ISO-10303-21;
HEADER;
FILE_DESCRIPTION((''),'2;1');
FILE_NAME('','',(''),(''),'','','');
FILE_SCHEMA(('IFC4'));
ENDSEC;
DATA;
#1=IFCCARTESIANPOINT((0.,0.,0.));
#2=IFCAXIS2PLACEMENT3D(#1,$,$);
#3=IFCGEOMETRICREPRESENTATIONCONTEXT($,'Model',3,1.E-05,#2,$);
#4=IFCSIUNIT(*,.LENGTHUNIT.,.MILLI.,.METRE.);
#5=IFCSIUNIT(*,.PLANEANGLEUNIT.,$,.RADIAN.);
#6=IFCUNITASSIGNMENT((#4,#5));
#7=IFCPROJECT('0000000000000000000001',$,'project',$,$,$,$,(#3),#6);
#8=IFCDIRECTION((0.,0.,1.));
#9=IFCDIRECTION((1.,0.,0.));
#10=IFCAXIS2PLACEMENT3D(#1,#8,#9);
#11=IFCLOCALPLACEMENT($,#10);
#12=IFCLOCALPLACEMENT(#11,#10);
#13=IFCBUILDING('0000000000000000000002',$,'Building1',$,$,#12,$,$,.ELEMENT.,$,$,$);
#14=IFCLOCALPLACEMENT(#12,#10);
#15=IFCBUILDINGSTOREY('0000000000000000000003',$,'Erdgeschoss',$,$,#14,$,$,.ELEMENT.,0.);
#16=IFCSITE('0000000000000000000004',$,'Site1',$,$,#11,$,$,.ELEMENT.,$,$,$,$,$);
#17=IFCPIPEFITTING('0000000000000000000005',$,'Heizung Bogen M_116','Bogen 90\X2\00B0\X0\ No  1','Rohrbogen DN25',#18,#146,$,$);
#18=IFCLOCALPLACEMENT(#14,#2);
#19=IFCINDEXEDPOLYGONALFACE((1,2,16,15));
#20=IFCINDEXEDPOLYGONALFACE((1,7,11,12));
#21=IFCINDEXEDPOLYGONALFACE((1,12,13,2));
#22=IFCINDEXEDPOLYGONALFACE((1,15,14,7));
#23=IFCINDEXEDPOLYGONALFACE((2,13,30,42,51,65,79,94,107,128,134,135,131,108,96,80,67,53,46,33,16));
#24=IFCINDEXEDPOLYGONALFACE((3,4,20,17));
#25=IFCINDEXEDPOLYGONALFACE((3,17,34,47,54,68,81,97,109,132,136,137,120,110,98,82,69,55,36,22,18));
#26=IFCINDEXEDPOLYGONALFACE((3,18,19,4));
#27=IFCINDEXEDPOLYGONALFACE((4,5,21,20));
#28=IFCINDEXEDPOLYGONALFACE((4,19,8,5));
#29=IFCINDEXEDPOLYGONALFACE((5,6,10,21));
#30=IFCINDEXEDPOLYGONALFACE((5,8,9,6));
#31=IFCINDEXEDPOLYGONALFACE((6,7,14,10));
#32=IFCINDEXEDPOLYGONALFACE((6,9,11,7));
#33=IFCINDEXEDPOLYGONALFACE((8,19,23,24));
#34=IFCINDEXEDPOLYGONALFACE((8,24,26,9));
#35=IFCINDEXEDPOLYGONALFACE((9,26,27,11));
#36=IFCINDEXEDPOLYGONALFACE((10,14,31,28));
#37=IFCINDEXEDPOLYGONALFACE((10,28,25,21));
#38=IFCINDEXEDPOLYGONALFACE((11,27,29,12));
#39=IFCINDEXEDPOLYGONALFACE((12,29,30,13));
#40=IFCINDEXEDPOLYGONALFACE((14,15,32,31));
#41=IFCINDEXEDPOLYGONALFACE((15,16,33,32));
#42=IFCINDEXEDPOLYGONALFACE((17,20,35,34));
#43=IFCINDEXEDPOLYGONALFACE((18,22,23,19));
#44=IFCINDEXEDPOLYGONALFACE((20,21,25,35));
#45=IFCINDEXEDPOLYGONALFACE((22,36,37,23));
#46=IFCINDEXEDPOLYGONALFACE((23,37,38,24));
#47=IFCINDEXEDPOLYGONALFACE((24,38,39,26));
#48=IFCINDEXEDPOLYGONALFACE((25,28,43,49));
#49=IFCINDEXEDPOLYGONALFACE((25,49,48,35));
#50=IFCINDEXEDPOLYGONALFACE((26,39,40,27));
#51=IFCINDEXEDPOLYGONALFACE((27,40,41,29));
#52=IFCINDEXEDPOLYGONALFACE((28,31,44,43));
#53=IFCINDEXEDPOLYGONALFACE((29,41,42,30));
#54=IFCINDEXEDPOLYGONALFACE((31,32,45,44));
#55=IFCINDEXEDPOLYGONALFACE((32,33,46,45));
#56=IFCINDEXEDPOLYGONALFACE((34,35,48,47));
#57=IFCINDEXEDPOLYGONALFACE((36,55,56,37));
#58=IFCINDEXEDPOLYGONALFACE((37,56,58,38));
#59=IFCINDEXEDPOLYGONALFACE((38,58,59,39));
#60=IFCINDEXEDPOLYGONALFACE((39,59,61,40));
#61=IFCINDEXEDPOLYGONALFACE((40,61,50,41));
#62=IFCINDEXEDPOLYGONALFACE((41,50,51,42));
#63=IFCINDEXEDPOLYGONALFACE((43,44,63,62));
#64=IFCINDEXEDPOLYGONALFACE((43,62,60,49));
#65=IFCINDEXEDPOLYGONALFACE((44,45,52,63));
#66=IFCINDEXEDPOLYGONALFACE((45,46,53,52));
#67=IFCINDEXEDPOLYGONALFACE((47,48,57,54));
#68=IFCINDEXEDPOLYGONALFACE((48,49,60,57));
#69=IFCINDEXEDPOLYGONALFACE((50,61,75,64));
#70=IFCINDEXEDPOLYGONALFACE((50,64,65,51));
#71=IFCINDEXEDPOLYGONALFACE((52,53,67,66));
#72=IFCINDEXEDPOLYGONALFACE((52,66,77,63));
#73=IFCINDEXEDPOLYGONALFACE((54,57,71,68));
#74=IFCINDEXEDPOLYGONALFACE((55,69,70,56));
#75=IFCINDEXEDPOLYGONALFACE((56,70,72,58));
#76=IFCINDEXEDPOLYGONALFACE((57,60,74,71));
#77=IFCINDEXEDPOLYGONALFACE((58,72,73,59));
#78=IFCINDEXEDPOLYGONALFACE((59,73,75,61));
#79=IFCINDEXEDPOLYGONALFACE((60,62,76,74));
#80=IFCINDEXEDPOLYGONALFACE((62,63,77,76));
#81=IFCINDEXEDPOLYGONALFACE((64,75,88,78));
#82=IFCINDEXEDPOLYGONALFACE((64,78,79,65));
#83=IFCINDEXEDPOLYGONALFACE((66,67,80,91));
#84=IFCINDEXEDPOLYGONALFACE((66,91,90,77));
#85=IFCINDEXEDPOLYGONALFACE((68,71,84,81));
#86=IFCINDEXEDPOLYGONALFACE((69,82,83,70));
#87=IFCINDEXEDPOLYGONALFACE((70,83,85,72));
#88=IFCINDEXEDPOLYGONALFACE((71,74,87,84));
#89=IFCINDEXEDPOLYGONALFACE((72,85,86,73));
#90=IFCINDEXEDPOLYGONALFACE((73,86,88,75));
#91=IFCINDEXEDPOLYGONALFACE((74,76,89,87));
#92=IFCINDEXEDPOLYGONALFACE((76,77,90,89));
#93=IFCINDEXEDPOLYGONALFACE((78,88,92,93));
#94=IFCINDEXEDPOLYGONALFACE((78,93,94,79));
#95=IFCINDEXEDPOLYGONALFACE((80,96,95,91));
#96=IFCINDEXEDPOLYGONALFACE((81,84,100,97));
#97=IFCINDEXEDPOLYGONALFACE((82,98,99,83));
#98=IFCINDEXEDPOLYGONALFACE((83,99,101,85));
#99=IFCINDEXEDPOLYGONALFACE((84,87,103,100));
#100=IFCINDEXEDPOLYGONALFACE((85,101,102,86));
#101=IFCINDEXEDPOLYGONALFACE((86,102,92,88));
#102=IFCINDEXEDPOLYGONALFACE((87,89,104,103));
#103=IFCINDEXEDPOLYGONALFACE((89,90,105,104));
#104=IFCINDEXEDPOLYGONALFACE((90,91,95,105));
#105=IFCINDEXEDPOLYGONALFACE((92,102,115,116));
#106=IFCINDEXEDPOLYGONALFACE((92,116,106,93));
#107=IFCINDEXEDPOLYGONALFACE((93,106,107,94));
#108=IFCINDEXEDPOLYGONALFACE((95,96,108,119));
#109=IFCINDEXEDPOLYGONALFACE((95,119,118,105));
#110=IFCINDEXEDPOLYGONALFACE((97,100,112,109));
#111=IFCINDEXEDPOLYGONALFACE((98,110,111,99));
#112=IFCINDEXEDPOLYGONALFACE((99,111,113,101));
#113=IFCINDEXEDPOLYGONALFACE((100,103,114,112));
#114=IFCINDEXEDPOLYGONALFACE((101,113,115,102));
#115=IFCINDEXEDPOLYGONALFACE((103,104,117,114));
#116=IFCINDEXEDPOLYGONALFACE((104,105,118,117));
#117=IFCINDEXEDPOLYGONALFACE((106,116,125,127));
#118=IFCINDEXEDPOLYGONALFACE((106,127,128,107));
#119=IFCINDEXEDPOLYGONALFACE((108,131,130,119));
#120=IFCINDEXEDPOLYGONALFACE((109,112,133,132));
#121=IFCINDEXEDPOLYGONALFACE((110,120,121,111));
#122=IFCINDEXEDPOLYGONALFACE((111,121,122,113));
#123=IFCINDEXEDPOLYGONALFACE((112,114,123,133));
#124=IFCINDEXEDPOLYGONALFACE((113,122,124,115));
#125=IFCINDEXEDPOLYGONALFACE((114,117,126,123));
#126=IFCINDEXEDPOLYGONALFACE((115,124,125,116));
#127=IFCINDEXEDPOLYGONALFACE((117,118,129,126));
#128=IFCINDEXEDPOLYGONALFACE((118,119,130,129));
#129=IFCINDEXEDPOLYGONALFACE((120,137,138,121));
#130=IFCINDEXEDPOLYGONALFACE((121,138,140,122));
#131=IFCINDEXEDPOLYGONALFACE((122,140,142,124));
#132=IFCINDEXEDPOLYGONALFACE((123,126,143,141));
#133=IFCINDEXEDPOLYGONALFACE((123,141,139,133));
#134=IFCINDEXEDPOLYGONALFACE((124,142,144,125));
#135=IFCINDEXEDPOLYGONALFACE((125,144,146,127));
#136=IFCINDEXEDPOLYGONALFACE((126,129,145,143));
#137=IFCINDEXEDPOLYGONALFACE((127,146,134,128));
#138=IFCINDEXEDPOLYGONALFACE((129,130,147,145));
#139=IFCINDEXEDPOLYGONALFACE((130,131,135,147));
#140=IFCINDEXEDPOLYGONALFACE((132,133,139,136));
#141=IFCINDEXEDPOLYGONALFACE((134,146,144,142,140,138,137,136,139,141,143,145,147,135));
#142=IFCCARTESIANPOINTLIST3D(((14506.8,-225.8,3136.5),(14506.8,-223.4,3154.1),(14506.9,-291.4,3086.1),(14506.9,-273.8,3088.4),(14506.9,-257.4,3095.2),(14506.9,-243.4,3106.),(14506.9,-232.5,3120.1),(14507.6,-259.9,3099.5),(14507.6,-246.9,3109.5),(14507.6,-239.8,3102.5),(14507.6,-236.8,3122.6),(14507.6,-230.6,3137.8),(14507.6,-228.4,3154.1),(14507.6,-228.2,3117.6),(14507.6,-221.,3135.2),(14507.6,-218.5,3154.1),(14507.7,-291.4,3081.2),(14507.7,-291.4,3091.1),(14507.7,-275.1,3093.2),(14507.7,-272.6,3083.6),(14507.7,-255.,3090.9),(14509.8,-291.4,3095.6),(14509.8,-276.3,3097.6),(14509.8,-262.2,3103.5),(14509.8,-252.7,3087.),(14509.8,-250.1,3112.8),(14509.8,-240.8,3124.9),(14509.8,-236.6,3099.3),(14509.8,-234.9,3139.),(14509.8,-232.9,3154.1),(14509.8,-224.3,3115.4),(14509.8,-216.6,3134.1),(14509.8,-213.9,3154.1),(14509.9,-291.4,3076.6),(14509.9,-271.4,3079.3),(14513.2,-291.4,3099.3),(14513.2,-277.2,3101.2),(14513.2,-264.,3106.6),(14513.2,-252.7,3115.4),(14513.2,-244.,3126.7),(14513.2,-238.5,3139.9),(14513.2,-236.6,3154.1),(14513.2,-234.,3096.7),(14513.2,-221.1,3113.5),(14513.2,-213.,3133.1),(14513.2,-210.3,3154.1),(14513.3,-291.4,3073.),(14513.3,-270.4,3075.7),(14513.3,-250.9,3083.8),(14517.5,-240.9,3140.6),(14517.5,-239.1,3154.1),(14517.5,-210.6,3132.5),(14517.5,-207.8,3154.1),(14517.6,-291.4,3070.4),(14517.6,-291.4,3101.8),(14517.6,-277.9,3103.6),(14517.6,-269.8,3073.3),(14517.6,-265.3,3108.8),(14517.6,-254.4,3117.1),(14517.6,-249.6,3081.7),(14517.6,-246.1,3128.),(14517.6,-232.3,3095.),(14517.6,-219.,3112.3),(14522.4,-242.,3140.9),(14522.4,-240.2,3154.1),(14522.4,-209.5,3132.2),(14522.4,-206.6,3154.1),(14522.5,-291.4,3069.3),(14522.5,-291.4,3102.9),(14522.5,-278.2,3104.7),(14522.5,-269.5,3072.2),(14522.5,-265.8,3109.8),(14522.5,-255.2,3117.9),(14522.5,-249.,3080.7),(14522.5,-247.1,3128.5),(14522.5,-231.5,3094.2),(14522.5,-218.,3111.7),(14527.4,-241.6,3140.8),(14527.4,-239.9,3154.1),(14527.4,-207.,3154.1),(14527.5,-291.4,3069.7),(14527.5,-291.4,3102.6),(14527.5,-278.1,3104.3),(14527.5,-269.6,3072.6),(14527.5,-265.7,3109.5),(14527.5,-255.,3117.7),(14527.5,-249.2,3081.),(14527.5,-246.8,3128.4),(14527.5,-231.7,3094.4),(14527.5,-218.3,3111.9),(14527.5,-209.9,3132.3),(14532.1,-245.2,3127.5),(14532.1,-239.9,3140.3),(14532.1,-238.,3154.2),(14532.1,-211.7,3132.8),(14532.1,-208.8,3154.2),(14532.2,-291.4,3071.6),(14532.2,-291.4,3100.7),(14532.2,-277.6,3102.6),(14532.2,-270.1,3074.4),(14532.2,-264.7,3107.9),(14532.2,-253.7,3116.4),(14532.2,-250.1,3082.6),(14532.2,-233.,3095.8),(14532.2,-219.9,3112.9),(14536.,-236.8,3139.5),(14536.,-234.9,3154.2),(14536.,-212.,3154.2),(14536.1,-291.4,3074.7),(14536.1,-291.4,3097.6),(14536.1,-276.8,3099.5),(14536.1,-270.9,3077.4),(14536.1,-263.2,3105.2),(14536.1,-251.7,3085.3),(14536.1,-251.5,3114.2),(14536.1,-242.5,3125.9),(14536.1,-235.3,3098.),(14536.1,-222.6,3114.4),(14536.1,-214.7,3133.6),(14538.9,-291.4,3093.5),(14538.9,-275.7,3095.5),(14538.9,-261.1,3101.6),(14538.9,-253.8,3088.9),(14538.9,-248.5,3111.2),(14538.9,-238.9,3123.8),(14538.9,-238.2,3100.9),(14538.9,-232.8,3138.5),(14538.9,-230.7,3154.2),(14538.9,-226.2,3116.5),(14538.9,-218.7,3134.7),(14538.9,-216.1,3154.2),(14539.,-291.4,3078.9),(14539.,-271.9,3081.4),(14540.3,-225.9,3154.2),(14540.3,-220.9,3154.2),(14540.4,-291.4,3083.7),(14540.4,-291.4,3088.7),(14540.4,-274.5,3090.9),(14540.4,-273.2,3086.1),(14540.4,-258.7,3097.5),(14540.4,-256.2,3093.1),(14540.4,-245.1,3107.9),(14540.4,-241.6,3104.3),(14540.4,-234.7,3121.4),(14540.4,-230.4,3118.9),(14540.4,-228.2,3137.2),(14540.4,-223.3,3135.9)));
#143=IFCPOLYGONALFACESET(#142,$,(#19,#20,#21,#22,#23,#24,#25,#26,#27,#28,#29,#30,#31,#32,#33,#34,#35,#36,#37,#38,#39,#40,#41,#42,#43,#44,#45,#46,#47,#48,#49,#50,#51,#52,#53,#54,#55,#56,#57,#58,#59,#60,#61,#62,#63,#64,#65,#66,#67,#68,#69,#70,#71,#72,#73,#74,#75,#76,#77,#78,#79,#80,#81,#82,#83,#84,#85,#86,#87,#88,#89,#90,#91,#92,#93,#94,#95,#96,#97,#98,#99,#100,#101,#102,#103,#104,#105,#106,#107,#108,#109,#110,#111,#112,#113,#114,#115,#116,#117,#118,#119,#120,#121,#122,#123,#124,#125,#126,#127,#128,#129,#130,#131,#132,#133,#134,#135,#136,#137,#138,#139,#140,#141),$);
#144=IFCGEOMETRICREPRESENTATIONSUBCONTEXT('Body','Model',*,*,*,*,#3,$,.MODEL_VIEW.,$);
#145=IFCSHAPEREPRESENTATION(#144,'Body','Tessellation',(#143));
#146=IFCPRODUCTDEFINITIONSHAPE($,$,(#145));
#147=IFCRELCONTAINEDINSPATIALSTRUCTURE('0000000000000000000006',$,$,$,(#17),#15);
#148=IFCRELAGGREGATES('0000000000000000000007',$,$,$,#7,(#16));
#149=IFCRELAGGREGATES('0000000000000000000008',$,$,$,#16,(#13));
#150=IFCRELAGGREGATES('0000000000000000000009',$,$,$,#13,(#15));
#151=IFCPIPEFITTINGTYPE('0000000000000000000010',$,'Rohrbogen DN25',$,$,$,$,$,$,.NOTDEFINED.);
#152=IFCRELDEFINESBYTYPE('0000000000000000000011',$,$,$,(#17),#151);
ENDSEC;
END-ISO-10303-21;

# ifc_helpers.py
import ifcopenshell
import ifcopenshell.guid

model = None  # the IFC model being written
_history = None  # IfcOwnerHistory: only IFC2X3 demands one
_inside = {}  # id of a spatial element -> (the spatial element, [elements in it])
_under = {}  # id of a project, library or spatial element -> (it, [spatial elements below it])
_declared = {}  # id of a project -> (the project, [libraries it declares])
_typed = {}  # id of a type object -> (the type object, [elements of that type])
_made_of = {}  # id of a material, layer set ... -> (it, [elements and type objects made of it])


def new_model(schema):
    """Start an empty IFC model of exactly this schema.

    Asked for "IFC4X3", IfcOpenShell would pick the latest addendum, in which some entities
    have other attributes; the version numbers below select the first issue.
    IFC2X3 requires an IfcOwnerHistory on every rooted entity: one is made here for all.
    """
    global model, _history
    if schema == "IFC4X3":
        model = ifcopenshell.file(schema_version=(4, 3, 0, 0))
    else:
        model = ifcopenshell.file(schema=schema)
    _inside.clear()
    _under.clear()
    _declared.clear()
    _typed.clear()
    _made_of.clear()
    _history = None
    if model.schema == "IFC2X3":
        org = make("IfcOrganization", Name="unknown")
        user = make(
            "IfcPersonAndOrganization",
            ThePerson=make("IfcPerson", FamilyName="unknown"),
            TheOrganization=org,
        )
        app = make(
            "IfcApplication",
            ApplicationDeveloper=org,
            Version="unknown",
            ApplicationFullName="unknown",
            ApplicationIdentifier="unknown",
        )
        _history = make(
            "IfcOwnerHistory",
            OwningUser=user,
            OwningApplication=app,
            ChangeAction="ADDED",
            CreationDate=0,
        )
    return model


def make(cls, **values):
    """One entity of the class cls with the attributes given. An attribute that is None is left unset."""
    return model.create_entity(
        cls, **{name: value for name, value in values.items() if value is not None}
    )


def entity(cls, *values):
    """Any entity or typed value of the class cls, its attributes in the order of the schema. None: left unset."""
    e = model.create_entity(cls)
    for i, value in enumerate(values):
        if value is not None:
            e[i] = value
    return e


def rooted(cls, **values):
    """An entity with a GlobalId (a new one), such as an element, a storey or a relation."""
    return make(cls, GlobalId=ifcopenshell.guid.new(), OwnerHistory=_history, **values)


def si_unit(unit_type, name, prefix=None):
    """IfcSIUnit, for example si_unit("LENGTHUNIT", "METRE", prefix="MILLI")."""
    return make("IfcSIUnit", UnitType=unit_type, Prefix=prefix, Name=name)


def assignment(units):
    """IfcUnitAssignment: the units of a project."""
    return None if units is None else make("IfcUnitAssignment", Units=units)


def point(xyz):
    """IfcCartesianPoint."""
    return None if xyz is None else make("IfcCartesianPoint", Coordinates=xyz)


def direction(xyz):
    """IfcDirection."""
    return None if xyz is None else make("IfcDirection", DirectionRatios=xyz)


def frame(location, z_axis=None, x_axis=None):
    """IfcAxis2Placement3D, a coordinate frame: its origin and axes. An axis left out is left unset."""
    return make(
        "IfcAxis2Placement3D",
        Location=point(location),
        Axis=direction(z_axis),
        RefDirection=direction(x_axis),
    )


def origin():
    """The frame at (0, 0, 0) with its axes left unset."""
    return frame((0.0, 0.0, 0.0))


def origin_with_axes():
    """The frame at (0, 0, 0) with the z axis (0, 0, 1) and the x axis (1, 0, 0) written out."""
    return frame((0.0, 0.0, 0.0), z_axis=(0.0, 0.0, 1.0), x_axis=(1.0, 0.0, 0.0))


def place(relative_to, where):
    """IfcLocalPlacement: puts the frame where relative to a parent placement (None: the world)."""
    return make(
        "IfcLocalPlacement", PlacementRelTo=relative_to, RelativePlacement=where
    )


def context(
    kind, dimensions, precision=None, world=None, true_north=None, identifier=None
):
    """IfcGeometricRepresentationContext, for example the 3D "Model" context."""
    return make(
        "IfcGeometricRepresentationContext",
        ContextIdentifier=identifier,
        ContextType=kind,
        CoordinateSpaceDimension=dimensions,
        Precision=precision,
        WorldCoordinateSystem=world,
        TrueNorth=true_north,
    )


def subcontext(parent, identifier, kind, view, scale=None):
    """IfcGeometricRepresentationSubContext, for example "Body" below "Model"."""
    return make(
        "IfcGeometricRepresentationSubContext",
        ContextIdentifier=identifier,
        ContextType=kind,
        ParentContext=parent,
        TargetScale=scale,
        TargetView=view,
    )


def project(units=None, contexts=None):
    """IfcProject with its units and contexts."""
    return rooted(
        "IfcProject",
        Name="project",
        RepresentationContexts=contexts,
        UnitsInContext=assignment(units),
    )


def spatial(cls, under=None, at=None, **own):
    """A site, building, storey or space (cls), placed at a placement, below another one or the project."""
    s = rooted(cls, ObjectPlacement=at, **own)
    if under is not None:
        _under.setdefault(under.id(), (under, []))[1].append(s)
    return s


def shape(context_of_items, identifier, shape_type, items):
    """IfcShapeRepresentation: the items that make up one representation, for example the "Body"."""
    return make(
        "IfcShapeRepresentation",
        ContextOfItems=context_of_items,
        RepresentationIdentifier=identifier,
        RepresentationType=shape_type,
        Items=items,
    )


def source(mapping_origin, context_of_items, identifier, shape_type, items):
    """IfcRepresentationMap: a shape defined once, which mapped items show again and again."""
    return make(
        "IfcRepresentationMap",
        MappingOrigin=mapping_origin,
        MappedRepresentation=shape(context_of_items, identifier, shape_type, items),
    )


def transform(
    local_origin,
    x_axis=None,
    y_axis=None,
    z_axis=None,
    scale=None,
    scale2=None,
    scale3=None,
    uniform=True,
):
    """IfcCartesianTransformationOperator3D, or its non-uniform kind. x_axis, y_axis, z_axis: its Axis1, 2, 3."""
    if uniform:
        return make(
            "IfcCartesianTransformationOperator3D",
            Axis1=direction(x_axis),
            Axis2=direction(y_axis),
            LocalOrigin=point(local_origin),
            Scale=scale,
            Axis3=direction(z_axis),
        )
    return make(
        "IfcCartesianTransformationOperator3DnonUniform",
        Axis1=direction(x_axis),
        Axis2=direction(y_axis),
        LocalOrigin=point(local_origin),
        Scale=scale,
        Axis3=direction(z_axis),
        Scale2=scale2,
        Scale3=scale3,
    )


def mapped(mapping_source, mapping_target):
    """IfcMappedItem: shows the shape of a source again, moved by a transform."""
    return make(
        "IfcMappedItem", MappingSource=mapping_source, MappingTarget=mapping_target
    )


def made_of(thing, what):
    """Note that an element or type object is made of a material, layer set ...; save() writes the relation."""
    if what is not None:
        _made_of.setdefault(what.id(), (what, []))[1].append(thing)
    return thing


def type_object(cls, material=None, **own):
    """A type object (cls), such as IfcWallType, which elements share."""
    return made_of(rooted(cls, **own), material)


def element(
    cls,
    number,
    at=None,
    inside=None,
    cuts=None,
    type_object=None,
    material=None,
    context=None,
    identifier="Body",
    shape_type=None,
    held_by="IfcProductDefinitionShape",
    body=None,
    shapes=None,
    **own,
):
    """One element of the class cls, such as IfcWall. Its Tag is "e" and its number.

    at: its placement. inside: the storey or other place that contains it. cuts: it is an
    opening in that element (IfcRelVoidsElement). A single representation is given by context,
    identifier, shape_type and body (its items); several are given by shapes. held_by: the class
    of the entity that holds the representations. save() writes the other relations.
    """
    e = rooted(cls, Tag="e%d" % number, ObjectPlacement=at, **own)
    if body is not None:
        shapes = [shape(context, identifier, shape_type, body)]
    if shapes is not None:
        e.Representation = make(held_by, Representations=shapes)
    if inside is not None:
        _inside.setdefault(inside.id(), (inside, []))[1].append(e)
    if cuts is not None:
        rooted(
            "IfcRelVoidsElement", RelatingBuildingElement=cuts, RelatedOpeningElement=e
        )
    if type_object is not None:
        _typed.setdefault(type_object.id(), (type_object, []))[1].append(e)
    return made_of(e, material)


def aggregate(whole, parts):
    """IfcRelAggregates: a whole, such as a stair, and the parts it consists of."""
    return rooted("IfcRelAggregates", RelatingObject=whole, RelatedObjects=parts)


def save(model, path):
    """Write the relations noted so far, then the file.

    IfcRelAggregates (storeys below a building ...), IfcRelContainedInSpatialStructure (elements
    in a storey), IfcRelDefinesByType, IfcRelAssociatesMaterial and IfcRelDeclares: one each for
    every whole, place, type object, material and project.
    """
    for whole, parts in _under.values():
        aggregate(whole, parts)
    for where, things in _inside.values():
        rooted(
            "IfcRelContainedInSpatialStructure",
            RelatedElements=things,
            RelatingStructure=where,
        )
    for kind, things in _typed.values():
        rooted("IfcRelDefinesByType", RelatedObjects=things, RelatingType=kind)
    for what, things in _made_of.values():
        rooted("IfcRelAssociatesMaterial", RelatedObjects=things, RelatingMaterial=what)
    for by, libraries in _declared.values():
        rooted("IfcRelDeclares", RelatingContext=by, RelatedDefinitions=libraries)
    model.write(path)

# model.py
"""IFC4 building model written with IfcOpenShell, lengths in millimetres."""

from ifc_helpers import new_model, entity, si_unit, frame, origin, origin_with_axes, place, context, subcontext, project, spatial, source, transform, mapped, type_object, element, save


model = new_model("IFC4")

# Units and contexts
model_context = context("Model", 3, precision=1e-05, world=origin())
body_context = subcontext(model_context, "Body", "Model", "MODEL_VIEW")
ifc_project = project(units=[si_unit("LENGTHUNIT", "METRE", prefix="MILLI"), si_unit("PLANEANGLEUNIT", "RADIAN")], contexts=[model_context])

# Site, building, storey
site_placement = place(None, origin_with_axes())
site = spatial("IfcSite", under=ifc_project, at=site_placement, Name="Site1", CompositionType="ELEMENT")
building_placement = place(site_placement, origin_with_axes())
building = spatial("IfcBuilding", under=site, at=building_placement, Name="Building1", CompositionType="ELEMENT")
storey_placement = place(building_placement, origin_with_axes())
storey = spatial("IfcBuildingStorey", under=building, at=storey_placement, Name="Erdgeschoss", CompositionType="ELEMENT", Elevation=0.0)

# Pipe fitting
pipe_fitting_type = type_object("IfcPipeFittingType", Name="Rohrbogen DN25", PredefinedType="NOTDEFINED")
shared_shape_1 = source(origin_with_axes(), body_context, "Body", "SolidModel", [
    entity("IfcRevolvedAreaSolid", entity("IfcCircleProfileDef", "AREA", None, entity("IfcAxis2Placement2D", entity("IfcCartesianPoint", [0.0, 0.0]), entity("IfcDirection", [1.0, 0.0])), 16.9), entity("IfcAxis2Placement3D", entity("IfcCartesianPoint", [-42.4, 0.1, 25.6]), entity("IfcDirection", [1.0, 0.0, 0.0]), entity("IfcDirection", [0.0, -0.999997, 0.002343])), entity("IfcAxis1Placement", entity("IfcCartesianPoint", [0.0, 68.0, 0.0]), entity("IfcDirection", [-1.0, 0.0, 0.0])), 1.570796),
])
pipe_fitting_1_placement = place(storey_placement, frame((14523.7, -249.0, 3111.7), z_axis=(0.0, 0.0, 1.0), x_axis=(1.0, 0.0, 0.0)))
element("IfcPipeFitting", 1, at=pipe_fitting_1_placement, inside=storey, type_object=pipe_fitting_type, Name="Heizung Bogen M_116", Description="Bogen 90° No  1", ObjectType="Rohrbogen DN25", context=body_context, shape_type="MappedRepresentation", body=[
    mapped(shared_shape_1, transform((0.0, 0.0, 0.0), x_axis=(0.000001, 1.0, 0.0), y_axis=(1.0, -0.000001, -0.000979), z_axis=(-0.000979, 0.0, -1.0), scale=1.0)),
])

save(model, "model.ifc")
